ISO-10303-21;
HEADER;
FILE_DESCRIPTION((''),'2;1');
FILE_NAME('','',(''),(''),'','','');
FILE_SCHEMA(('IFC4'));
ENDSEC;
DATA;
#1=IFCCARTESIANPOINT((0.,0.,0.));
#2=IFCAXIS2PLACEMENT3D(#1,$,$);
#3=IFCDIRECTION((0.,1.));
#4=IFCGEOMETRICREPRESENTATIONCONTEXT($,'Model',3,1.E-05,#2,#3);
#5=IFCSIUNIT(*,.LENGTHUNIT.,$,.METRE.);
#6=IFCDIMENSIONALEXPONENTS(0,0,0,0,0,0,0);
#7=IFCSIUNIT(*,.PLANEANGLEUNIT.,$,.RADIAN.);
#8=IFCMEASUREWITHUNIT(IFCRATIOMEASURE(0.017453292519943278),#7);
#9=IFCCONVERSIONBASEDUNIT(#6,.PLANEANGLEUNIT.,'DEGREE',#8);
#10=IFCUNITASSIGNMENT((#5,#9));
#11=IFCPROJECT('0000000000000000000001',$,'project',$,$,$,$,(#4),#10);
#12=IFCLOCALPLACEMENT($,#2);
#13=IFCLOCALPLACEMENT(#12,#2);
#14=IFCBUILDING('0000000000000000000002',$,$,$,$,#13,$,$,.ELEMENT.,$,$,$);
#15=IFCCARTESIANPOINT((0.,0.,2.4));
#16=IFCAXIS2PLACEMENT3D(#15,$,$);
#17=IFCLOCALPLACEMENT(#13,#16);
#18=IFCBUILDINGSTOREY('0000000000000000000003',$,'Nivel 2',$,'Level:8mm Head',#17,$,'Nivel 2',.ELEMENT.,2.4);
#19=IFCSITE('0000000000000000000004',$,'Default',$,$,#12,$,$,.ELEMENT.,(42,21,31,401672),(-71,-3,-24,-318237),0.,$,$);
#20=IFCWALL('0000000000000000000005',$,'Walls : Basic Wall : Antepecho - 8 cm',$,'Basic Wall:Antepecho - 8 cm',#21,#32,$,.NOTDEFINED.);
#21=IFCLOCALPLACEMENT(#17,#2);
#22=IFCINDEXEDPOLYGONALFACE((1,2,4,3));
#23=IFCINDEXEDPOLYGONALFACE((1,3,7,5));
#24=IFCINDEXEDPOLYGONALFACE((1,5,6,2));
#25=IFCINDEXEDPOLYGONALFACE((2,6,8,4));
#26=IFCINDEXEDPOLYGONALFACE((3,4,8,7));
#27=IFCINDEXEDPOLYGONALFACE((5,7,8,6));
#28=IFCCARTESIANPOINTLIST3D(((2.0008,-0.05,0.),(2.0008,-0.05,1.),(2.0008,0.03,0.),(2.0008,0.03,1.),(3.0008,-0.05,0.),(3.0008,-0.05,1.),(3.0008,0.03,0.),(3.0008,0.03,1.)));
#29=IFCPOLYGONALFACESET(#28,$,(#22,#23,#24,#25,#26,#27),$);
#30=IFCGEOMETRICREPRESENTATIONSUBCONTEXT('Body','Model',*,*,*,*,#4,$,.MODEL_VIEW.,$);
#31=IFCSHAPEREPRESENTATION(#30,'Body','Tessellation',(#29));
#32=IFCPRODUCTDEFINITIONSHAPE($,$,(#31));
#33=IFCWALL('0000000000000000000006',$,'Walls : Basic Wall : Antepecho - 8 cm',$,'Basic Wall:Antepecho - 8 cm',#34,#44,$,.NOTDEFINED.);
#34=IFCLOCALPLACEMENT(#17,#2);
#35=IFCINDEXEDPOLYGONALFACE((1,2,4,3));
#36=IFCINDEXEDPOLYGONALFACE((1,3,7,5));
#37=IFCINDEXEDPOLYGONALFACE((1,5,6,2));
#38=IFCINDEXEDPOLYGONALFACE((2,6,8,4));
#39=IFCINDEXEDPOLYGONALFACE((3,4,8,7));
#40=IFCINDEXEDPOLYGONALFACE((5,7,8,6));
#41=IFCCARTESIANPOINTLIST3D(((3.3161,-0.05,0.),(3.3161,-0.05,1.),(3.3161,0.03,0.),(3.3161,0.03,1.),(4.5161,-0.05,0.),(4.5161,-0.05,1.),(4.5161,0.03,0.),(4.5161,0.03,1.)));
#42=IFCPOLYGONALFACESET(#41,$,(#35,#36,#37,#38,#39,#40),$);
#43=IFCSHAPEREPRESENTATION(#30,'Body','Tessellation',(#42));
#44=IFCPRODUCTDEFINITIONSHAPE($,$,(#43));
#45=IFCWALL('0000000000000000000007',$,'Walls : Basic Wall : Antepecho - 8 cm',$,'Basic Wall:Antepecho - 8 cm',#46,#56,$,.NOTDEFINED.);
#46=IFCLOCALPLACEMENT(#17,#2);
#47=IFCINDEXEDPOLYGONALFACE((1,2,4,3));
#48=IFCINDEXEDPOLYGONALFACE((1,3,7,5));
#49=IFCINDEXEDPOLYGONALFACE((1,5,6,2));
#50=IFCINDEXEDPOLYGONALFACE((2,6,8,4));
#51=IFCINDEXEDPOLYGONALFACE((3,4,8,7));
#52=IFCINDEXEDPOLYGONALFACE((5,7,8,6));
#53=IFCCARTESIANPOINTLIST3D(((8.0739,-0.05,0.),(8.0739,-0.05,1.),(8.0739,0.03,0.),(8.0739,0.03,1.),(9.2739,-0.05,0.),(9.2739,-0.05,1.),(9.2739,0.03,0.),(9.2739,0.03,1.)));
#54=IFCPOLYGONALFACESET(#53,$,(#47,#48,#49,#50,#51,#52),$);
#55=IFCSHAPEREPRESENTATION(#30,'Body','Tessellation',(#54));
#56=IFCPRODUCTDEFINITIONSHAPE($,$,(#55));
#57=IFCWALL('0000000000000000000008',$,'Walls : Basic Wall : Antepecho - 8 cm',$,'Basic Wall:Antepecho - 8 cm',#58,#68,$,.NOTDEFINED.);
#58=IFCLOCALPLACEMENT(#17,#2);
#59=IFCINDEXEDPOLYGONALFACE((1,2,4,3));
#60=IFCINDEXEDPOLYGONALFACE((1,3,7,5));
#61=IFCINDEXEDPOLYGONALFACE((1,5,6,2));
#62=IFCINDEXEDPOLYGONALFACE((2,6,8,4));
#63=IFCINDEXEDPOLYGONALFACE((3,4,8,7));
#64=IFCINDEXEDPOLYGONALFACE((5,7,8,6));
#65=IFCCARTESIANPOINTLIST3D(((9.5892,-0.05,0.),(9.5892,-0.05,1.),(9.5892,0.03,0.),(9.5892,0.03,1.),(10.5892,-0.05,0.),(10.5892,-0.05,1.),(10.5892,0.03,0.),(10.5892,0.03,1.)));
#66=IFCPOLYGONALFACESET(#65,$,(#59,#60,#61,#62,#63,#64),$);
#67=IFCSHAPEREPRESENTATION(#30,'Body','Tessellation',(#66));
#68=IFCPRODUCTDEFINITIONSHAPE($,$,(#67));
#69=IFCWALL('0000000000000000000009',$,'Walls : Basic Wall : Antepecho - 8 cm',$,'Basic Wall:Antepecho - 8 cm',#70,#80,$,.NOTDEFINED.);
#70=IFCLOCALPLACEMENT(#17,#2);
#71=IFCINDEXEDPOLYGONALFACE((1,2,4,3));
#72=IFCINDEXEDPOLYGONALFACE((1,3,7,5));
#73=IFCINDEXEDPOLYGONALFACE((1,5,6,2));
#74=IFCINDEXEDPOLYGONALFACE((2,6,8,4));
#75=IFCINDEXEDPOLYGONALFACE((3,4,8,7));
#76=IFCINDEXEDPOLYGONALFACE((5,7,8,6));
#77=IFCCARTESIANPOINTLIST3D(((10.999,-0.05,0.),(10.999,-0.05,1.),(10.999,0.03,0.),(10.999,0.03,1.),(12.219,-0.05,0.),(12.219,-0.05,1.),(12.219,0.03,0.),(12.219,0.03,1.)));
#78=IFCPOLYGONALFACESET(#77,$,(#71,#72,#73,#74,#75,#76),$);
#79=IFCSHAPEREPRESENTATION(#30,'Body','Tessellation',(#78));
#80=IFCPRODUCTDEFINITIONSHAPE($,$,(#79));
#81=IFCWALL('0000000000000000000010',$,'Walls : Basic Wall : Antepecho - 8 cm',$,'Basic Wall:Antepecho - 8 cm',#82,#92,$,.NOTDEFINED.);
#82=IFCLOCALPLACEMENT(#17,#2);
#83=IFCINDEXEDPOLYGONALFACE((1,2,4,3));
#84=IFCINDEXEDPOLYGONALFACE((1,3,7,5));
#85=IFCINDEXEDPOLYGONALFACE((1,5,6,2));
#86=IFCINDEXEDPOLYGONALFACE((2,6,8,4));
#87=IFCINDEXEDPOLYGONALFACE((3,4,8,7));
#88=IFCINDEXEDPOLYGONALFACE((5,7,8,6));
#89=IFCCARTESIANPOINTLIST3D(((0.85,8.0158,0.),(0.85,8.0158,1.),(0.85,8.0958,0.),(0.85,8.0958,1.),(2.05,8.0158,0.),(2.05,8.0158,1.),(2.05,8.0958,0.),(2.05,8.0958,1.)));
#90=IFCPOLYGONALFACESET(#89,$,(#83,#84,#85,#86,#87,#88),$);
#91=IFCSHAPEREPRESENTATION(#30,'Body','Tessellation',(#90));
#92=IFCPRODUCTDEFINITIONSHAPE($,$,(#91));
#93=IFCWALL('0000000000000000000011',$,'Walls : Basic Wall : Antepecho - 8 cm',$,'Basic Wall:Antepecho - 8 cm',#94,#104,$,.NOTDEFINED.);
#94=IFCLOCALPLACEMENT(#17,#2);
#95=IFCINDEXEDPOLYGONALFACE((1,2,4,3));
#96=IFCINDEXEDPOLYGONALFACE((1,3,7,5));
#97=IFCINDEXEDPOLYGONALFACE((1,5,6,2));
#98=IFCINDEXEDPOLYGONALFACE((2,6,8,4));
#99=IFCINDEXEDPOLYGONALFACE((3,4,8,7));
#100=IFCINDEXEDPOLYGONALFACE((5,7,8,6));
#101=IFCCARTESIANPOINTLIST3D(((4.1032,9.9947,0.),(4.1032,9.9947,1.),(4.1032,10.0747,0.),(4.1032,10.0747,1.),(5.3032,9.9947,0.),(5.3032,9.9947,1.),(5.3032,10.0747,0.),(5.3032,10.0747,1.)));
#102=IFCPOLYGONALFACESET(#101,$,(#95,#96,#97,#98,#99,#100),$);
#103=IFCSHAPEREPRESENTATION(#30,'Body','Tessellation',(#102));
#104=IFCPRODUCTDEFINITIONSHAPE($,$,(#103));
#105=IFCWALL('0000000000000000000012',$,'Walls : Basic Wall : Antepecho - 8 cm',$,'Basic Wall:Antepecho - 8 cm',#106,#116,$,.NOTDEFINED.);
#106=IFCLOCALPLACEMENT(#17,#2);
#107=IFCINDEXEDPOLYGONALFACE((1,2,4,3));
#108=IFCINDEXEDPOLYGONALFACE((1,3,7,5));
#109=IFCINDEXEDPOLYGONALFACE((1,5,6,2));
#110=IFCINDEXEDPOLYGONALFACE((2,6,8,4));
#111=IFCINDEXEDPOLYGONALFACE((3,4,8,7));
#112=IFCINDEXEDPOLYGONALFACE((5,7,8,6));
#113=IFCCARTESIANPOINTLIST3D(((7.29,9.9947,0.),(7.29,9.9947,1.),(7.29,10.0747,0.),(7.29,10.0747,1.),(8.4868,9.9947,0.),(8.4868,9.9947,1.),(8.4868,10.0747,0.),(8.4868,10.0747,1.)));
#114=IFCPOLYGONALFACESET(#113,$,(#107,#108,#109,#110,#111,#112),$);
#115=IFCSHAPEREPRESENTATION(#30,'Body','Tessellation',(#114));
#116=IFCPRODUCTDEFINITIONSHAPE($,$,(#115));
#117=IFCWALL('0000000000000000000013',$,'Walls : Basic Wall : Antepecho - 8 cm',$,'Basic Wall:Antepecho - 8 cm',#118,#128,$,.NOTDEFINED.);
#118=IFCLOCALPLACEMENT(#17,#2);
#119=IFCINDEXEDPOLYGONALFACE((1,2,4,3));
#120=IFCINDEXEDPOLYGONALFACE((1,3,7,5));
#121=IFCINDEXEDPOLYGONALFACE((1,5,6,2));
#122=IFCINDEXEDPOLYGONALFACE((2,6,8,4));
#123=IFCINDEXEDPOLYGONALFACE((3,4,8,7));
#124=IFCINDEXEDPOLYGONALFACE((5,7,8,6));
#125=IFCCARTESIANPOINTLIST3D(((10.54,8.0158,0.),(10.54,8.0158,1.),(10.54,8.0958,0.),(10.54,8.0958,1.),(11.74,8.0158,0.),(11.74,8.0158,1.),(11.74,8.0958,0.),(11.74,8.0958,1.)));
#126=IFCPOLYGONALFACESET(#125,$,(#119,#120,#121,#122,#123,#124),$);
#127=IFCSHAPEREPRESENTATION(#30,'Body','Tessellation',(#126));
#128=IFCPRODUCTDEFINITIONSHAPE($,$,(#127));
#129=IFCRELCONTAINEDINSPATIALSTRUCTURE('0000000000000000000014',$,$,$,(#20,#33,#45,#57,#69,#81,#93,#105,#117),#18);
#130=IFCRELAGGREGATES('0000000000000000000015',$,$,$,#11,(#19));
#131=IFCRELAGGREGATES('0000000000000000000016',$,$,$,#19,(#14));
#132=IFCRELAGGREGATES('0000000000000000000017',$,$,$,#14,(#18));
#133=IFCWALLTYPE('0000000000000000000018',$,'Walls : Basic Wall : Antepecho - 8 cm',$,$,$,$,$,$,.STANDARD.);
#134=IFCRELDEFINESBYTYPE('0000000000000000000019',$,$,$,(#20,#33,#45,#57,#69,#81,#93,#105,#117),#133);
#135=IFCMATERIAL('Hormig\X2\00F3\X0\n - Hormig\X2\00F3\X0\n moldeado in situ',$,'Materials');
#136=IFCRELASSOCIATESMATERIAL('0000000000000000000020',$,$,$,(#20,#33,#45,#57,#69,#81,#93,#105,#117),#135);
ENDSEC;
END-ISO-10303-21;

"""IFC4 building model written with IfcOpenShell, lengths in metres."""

from ifc_helpers import new_model, entity, si_unit, converted_unit, direction, frame, origin, place, context, subcontext, project, spatial, indexed_curve, outline, extrude, material, type_object, element, save


model = new_model("IFC4")

# Units and contexts
model_context = context("Model", 3, precision=1e-05, world=origin(), true_north=direction((0.0, 1.0)))
body_context = subcontext(model_context, "Body", "Model", "MODEL_VIEW")
ifc_project = project(units=[si_unit("LENGTHUNIT", "METRE"), converted_unit("PLANEANGLEUNIT", "DEGREE", entity("IfcRatioMeasure", 0.017453292519943278), si_unit("PLANEANGLEUNIT", "RADIAN"), dimensions=[0, 0, 0, 0, 0, 0, 0])], contexts=[model_context])

# Site, building, storey
site_placement = place(None, origin())
site = spatial("IfcSite", under=ifc_project, at=site_placement, Name="Default", CompositionType="ELEMENT", RefLatitude=(42, 21, 31, 401672), RefLongitude=(-71, -3, -24, -318237), RefElevation=0.0)
building_placement = place(site_placement, origin())
building = spatial("IfcBuilding", under=site, at=building_placement, CompositionType="ELEMENT")
storey_placement = place(building_placement, frame((0.0, 0.0, 2.4)))
storey = spatial("IfcBuildingStorey", under=building, at=storey_placement, Name="Nivel 2", ObjectType="Level:8mm Head", LongName="Nivel 2", CompositionType="ELEMENT", Elevation=2.4)

# Shared definitions
ifc_material_1 = material(Name="Hormigón - Hormigón moldeado in situ", Category="Materials")

# Walls
wall_type = type_object("IfcWallType", Name="Walls : Basic Wall : Antepecho - 8 cm", PredefinedType="STANDARD")
wall_1_placement = place(storey_placement, frame((2.0008, -0.01, 0.0)))
element("IfcWall", 1, at=wall_1_placement, inside=storey, type_object=wall_type, material=ifc_material_1, Name="Walls : Basic Wall : Antepecho - 8 cm", ObjectType="Basic Wall:Antepecho - 8 cm", PredefinedType="NOTDEFINED", context=body_context, shape_type="SweptSolid", body=[
    extrude(outline(indexed_curve([(1.0, 0.04), (0.0, 0.04), (0.0, -0.04), (1.0, -0.04), (1.0, 0.04)], self_intersect=False)), origin(), (0.0, 0.0, 1.0), 1.0),
])
wall_2_placement = place(storey_placement, frame((3.3161, -0.01, 0.0)))
element("IfcWall", 2, at=wall_2_placement, inside=storey, type_object=wall_type, material=ifc_material_1, Name="Walls : Basic Wall : Antepecho - 8 cm", ObjectType="Basic Wall:Antepecho - 8 cm", PredefinedType="NOTDEFINED", context=body_context, shape_type="SweptSolid", body=[
    extrude(outline(indexed_curve([(1.2, 0.04), (0.0, 0.04), (0.0, -0.04), (1.2, -0.04), (1.2, 0.04)], self_intersect=False)), origin(), (0.0, 0.0, 1.0), 1.0),
])
wall_3_placement = place(storey_placement, frame((8.0739, -0.01, 0.0)))
element("IfcWall", 3, at=wall_3_placement, inside=storey, type_object=wall_type, material=ifc_material_1, Name="Walls : Basic Wall : Antepecho - 8 cm", ObjectType="Basic Wall:Antepecho - 8 cm", PredefinedType="NOTDEFINED", context=body_context, shape_type="SweptSolid", body=[
    extrude(outline(indexed_curve([(1.2, 0.04), (0.0, 0.04), (0.0, -0.04), (1.2, -0.04), (1.2, 0.04)], self_intersect=False)), origin(), (0.0, 0.0, 1.0), 1.0),
])
wall_4_placement = place(storey_placement, frame((9.5892, -0.01, 0.0)))
element("IfcWall", 4, at=wall_4_placement, inside=storey, type_object=wall_type, material=ifc_material_1, Name="Walls : Basic Wall : Antepecho - 8 cm", ObjectType="Basic Wall:Antepecho - 8 cm", PredefinedType="NOTDEFINED", context=body_context, shape_type="SweptSolid", body=[
    extrude(outline(indexed_curve([(1.0, 0.04), (0.0, 0.04), (0.0, -0.04), (1.0, -0.04), (1.0, 0.04)], self_intersect=False)), origin(), (0.0, 0.0, 1.0), 1.0),
])
wall_5_placement = place(storey_placement, frame((10.999, -0.01, 0.0)))
element("IfcWall", 5, at=wall_5_placement, inside=storey, type_object=wall_type, material=ifc_material_1, Name="Walls : Basic Wall : Antepecho - 8 cm", ObjectType="Basic Wall:Antepecho - 8 cm", PredefinedType="NOTDEFINED", context=body_context, shape_type="SweptSolid", body=[
    extrude(outline(indexed_curve([(1.22, 0.04), (0.0, 0.04), (0.0, -0.04), (1.22, -0.04), (1.22, 0.04)], self_intersect=False)), origin(), (0.0, 0.0, 1.0), 1.0),
])
wall_6_placement = place(storey_placement, frame((2.05, 8.0558, 0.0), z_axis=(0.0, 0.0, 1.0), x_axis=(-1.0, 0.0, 0.0)))
element("IfcWall", 6, at=wall_6_placement, inside=storey, type_object=wall_type, material=ifc_material_1, Name="Walls : Basic Wall : Antepecho - 8 cm", ObjectType="Basic Wall:Antepecho - 8 cm", PredefinedType="NOTDEFINED", context=body_context, shape_type="SweptSolid", body=[
    extrude(outline(indexed_curve([(1.2, 0.04), (0.0, 0.04), (0.0, -0.04), (1.2, -0.04), (1.2, 0.04)], self_intersect=False)), origin(), (0.0, 0.0, 1.0), 1.0),
])
wall_7_placement = place(storey_placement, frame((5.3032, 10.0347, 0.0), z_axis=(0.0, 0.0, 1.0), x_axis=(-1.0, 0.0, 0.0)))
element("IfcWall", 7, at=wall_7_placement, inside=storey, type_object=wall_type, material=ifc_material_1, Name="Walls : Basic Wall : Antepecho - 8 cm", ObjectType="Basic Wall:Antepecho - 8 cm", PredefinedType="NOTDEFINED", context=body_context, shape_type="SweptSolid", body=[
    extrude(outline(indexed_curve([(1.2, 0.04), (0.0, 0.04), (0.0, -0.04), (1.2, -0.04), (1.2, 0.04)], self_intersect=False)), origin(), (0.0, 0.0, 1.0), 1.0),
])
wall_8_placement = place(storey_placement, frame((8.4868, 10.0347, 0.0), z_axis=(0.0, 0.0, 1.0), x_axis=(-1.0, 0.0, 0.0)))
element("IfcWall", 8, at=wall_8_placement, inside=storey, type_object=wall_type, material=ifc_material_1, Name="Walls : Basic Wall : Antepecho - 8 cm", ObjectType="Basic Wall:Antepecho - 8 cm", PredefinedType="NOTDEFINED", context=body_context, shape_type="SweptSolid", body=[
    extrude(outline(indexed_curve([(1.1968, 0.04), (0.0, 0.04), (0.0, -0.04), (1.1968, -0.04), (1.1968, 0.04)], self_intersect=False)), origin(), (0.0, 0.0, 1.0), 1.0),
])
wall_9_placement = place(storey_placement, frame((11.74, 8.0558, 0.0), z_axis=(0.0, 0.0, 1.0), x_axis=(-1.0, 0.0, 0.0)))
element("IfcWall", 9, at=wall_9_placement, inside=storey, type_object=wall_type, material=ifc_material_1, Name="Walls : Basic Wall : Antepecho - 8 cm", ObjectType="Basic Wall:Antepecho - 8 cm", PredefinedType="NOTDEFINED", context=body_context, shape_type="SweptSolid", body=[
    extrude(outline(indexed_curve([(1.2, 0.04), (0.0, 0.04), (0.0, -0.04), (1.2, -0.04), (1.2, 0.04)], self_intersect=False)), origin(), (0.0, 0.0, 1.0), 1.0),
])

save(model, "model.ifc")
